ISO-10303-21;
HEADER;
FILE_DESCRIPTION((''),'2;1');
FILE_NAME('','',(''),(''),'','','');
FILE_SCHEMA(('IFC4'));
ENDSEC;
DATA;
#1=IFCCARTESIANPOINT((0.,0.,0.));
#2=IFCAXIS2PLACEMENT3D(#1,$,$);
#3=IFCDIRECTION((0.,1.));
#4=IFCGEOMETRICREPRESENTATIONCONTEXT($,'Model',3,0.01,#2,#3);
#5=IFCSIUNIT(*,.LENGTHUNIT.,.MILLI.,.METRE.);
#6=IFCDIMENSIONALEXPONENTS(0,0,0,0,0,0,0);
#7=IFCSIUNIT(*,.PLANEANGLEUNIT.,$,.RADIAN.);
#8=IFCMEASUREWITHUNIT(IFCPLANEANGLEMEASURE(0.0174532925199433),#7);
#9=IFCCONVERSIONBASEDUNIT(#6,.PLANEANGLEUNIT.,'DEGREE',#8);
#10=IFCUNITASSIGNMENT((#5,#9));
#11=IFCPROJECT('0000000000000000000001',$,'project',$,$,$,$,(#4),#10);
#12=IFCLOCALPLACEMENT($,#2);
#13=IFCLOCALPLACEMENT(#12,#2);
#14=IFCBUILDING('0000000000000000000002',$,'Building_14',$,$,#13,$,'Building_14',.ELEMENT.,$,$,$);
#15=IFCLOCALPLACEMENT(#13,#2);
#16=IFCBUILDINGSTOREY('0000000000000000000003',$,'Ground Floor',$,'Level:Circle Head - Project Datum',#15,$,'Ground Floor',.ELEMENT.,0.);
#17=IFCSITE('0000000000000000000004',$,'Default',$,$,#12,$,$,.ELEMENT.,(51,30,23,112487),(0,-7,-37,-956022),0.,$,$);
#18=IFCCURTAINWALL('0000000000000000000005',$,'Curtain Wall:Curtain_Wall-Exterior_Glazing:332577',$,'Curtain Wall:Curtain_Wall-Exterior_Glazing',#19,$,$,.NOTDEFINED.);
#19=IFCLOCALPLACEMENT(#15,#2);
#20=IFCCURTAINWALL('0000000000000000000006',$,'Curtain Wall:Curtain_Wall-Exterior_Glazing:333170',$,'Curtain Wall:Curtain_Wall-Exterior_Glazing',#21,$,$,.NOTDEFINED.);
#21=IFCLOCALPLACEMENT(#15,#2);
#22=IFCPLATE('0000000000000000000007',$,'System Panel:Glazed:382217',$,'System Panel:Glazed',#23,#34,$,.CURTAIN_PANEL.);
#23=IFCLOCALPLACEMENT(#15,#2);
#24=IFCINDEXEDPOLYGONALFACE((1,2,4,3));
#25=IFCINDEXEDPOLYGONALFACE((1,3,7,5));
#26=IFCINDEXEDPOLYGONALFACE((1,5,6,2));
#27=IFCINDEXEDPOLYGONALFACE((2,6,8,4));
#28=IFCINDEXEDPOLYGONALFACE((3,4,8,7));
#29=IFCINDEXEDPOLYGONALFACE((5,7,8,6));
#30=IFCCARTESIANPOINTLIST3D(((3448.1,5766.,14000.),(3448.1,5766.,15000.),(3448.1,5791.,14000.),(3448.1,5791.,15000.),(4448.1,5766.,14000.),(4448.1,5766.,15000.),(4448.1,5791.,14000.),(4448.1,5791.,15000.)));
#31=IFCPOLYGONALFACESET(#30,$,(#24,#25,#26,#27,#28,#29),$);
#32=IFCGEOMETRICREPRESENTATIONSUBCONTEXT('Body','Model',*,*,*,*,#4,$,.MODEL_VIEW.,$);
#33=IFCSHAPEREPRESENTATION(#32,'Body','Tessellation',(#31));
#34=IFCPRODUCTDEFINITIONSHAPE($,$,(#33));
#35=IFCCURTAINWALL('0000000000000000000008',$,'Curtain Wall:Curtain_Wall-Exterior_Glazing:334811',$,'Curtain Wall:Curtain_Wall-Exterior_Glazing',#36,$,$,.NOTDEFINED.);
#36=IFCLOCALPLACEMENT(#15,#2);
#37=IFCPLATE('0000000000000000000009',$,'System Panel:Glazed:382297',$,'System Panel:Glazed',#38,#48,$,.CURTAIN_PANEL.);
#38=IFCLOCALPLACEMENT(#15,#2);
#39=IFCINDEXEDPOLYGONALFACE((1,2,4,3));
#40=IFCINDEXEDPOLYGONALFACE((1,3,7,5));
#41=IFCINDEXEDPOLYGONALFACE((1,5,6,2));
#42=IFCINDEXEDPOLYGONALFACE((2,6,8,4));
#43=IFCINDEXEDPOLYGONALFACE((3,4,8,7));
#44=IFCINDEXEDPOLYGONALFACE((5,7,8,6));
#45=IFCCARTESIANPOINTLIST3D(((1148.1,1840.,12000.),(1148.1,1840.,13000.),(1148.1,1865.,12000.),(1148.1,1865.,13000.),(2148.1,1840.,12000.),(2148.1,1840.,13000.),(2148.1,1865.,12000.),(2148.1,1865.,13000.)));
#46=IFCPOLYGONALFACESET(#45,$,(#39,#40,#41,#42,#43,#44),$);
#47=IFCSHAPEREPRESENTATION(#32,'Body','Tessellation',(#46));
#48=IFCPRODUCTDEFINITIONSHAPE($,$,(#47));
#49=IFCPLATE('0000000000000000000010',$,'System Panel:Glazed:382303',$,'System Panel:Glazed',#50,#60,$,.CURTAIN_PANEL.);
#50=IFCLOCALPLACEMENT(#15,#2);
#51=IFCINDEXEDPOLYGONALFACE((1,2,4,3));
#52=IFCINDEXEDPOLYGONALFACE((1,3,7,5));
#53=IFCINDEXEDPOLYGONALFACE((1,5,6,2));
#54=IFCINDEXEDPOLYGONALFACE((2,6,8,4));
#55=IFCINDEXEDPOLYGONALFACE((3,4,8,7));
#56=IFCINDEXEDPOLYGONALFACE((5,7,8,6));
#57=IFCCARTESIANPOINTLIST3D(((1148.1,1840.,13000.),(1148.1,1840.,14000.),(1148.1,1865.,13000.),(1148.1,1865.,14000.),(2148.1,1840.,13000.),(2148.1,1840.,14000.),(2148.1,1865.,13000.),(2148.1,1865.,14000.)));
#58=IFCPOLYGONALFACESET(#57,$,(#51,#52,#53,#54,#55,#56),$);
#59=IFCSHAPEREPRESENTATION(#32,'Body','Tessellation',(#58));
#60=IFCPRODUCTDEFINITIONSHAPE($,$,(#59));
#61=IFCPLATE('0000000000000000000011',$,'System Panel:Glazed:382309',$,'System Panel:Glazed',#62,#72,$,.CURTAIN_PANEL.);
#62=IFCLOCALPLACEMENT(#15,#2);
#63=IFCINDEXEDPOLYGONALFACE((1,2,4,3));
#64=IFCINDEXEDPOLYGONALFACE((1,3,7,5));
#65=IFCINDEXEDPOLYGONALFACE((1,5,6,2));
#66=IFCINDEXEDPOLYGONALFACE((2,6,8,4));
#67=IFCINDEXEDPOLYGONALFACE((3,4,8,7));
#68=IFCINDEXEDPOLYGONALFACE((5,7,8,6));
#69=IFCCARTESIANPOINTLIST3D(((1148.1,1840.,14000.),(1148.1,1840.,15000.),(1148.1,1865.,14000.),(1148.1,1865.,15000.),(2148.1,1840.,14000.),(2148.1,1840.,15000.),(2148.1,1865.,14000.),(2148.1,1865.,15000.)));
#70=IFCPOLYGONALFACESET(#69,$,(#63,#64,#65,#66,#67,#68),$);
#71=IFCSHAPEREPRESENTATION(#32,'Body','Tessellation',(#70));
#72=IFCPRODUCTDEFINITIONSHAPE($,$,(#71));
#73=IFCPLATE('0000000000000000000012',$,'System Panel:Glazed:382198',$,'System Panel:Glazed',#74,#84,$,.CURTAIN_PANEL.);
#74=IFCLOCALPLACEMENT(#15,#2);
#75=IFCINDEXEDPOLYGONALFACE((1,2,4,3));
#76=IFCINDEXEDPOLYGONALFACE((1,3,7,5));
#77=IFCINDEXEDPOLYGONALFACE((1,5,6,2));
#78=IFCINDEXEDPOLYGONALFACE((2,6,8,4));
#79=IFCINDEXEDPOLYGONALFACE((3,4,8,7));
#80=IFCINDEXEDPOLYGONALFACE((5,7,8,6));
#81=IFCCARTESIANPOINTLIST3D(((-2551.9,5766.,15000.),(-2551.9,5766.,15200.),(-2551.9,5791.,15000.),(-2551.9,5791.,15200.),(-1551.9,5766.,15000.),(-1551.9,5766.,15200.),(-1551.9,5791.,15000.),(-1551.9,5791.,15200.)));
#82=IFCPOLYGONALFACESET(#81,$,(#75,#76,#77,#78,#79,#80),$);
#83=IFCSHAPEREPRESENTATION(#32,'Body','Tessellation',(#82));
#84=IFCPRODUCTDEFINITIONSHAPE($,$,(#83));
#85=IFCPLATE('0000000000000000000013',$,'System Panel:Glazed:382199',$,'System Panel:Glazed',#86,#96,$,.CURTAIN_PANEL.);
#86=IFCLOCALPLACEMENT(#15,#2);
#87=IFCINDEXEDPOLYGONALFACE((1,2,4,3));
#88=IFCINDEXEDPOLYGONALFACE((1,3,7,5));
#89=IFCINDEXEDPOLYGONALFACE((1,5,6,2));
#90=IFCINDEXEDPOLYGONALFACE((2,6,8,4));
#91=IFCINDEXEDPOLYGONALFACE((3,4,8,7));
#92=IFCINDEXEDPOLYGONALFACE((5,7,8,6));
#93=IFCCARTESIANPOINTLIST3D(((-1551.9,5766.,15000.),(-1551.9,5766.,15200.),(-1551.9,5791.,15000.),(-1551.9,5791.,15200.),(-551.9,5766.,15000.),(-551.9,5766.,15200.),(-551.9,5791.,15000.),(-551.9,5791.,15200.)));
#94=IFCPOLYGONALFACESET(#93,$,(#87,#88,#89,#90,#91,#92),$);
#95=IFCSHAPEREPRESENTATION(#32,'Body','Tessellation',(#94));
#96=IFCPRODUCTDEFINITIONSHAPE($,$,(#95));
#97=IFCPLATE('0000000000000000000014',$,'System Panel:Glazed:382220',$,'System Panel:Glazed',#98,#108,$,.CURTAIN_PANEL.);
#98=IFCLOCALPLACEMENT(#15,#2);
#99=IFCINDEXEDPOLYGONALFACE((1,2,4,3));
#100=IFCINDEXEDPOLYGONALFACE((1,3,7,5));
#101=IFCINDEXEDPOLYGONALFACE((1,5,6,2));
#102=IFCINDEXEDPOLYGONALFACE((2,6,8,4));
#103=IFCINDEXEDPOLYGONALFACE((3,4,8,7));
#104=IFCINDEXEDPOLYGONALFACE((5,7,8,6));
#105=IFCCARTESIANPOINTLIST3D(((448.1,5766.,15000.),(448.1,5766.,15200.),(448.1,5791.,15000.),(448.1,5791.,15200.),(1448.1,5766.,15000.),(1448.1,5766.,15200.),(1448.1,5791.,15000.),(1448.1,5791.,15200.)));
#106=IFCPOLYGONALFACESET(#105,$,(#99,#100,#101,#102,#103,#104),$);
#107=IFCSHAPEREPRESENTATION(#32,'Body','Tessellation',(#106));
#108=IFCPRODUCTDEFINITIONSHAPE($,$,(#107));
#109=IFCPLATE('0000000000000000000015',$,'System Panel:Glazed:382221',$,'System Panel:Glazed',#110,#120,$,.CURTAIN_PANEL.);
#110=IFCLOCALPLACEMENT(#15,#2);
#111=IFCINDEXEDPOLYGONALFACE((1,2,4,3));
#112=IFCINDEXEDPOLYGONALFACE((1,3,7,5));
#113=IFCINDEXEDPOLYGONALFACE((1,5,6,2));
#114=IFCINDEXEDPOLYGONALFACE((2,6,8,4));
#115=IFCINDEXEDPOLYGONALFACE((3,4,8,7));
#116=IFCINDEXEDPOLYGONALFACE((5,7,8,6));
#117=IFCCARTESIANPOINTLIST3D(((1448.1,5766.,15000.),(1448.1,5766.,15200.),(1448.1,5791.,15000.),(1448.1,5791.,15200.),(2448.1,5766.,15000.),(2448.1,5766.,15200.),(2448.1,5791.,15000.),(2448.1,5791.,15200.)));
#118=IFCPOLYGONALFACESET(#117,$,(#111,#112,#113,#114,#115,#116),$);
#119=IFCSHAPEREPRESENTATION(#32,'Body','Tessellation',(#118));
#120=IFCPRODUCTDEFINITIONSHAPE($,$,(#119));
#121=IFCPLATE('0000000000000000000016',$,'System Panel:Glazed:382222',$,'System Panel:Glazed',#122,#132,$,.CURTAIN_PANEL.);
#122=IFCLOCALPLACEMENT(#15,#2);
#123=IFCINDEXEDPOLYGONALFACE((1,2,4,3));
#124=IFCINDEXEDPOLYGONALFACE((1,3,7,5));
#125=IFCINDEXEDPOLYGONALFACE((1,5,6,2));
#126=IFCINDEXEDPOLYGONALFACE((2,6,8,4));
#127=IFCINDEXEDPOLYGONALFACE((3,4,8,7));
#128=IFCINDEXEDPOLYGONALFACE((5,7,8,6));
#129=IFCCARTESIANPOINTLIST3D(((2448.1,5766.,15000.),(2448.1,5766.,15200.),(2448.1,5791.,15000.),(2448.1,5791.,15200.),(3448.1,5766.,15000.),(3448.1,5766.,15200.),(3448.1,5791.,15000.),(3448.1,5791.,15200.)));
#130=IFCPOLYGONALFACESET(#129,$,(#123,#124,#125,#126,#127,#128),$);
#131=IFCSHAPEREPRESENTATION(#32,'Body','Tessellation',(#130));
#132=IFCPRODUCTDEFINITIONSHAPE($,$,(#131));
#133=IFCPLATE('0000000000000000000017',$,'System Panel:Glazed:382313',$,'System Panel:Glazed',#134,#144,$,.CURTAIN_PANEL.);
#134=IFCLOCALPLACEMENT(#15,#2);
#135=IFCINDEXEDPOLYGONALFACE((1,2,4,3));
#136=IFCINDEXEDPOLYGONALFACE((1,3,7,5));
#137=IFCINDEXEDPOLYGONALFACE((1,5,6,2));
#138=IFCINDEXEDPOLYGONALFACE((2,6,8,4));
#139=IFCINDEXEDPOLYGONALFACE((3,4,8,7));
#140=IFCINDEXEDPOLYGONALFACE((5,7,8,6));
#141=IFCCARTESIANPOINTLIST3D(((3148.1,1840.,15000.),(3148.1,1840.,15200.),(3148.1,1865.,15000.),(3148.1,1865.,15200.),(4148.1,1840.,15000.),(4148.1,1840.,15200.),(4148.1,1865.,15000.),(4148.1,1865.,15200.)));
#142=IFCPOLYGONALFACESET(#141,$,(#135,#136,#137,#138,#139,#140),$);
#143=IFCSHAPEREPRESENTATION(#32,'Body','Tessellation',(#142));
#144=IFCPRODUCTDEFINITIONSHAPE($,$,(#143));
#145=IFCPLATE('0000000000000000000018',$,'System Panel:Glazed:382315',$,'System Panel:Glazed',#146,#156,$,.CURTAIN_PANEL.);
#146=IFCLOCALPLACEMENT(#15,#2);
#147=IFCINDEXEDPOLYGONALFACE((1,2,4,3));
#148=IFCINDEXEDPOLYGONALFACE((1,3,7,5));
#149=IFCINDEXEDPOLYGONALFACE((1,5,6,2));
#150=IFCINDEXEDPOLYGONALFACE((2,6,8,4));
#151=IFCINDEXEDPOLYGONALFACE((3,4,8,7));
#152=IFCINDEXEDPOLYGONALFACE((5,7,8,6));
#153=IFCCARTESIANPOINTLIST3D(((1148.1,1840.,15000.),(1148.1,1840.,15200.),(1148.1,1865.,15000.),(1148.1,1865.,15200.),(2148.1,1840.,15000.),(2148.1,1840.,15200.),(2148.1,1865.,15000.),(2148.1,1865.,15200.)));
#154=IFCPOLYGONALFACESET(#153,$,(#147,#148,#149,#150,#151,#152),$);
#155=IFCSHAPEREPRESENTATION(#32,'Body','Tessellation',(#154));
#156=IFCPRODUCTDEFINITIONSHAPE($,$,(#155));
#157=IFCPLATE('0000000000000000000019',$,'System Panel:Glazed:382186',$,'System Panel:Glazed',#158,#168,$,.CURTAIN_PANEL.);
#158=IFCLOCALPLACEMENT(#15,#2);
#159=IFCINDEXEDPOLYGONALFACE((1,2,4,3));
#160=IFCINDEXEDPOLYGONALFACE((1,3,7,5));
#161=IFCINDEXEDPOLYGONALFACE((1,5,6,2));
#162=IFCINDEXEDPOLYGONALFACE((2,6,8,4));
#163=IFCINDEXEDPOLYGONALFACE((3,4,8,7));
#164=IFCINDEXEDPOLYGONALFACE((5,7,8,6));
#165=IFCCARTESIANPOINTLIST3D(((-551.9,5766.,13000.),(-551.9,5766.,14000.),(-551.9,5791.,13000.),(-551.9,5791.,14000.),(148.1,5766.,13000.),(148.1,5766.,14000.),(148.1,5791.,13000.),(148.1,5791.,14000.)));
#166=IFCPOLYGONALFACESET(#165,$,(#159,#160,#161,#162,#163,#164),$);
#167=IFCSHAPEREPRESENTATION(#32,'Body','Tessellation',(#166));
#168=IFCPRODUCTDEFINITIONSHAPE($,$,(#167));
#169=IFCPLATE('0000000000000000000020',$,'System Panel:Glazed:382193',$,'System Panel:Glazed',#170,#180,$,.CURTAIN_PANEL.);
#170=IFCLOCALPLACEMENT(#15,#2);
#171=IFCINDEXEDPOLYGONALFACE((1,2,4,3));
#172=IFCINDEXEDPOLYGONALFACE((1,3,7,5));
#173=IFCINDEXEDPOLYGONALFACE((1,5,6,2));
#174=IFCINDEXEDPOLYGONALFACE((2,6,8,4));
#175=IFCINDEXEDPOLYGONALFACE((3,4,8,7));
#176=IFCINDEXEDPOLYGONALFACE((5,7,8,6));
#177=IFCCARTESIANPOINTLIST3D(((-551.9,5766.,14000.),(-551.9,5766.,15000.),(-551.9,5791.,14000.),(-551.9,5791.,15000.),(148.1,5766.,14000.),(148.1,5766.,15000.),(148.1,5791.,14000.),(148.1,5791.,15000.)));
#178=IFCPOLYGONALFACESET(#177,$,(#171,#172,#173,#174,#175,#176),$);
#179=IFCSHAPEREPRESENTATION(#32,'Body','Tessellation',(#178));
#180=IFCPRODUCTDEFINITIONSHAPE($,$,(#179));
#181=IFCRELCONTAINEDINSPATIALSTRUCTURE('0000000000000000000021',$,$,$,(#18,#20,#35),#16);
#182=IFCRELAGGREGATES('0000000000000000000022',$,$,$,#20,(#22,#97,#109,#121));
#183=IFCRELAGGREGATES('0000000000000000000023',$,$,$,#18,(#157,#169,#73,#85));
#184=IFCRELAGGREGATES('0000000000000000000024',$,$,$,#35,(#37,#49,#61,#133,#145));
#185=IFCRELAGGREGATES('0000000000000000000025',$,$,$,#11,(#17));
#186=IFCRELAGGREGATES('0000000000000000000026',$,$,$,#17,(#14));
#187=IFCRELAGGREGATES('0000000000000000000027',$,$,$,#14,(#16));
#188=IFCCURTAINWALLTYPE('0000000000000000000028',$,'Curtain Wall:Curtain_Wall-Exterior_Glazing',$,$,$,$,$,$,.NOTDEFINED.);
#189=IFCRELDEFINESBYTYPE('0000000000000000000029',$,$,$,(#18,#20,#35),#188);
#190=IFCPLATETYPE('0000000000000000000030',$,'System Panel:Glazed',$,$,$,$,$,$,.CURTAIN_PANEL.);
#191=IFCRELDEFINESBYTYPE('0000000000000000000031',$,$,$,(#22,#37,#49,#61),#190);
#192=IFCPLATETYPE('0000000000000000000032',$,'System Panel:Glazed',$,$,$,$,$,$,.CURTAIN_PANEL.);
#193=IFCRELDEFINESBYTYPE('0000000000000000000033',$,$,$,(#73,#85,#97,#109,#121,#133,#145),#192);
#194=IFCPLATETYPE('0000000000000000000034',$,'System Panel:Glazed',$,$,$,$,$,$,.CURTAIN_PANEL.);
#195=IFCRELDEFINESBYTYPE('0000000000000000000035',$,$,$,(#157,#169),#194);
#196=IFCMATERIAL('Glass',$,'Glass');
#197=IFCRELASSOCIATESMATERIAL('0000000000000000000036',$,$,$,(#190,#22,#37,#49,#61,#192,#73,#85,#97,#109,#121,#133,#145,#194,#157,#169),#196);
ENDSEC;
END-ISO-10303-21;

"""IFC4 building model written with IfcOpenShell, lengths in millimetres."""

from ifc_helpers import new_model, entity, si_unit, converted_unit, direction, frame, origin, place, context, subcontext, project, spatial, indexed_curve, outline, extrude, source, transform, mapped, material, type_object, type_shapes, element, aggregate, save


model = new_model("IFC4")

# Units and contexts
model_context = context("Model", 3, precision=0.01, world=origin(), true_north=direction((0.0, 1.0)))
body_context = subcontext(model_context, "Body", "Model", "MODEL_VIEW")
ifc_project = project(units=[si_unit("LENGTHUNIT", "METRE", prefix="MILLI"), converted_unit("PLANEANGLEUNIT", "DEGREE", entity("IfcPlaneAngleMeasure", 0.0174532925199433), si_unit("PLANEANGLEUNIT", "RADIAN"), dimensions=[0, 0, 0, 0, 0, 0, 0])], contexts=[model_context])

# Site, building, storey
site_placement = place(None, origin())
site = spatial("IfcSite", under=ifc_project, at=site_placement, Name="Default", CompositionType="ELEMENT", RefLatitude=(51, 30, 23, 112487), RefLongitude=(0, -7, -37, -956022), RefElevation=0.0)
building_placement = place(site_placement, origin())
building = spatial("IfcBuilding", under=site, at=building_placement, Name="Building_14", LongName="Building_14", CompositionType="ELEMENT")
storey_placement = place(building_placement, origin())
storey = spatial("IfcBuildingStorey", under=building, at=storey_placement, Name="Ground Floor", ObjectType="Level:Circle Head - Project Datum", LongName="Ground Floor", CompositionType="ELEMENT", Elevation=0.0)

# Curtain walls, plates
curtain_wall_type = type_object("IfcCurtainWallType", Name="Curtain Wall:Curtain_Wall-Exterior_Glazing", PredefinedType="NOTDEFINED")
curtain_wall_1_placement = place(storey_placement, origin())
curtain_wall_1 = element("IfcCurtainWall", 1, at=curtain_wall_1_placement, inside=storey, type_object=curtain_wall_type, Name="Curtain Wall:Curtain_Wall-Exterior_Glazing:332577", ObjectType="Curtain Wall:Curtain_Wall-Exterior_Glazing", PredefinedType="NOTDEFINED")
ifc_material = material(Name="Glass", Category="Glass")
plate_type_1 = type_object("IfcPlateType", Name="System Panel:Glazed", PredefinedType="CURTAIN_PANEL", material=ifc_material)
shared_shape_1 = source(origin(), body_context, "Body", "SweptSolid", [
    extrude(outline(indexed_curve([(-12.5, -500.0), (12.5, -500.0), (12.5, 500.0), (-12.5, 500.0), (-12.5, -500.0)], self_intersect=False)), frame((0.0, -37.0, 0.0), z_axis=(0.0, 0.0, 1.0), x_axis=(0.0, 1.0, 0.0)), (0.0, 0.0, 1.0), 1000.0),
])
type_shapes(plate_type_1, [shared_shape_1])
curtain_wall_2_placement = place(storey_placement, origin())
curtain_wall_2 = element("IfcCurtainWall", 2, at=curtain_wall_2_placement, inside=storey, type_object=curtain_wall_type, Name="Curtain Wall:Curtain_Wall-Exterior_Glazing:333170", ObjectType="Curtain Wall:Curtain_Wall-Exterior_Glazing", PredefinedType="NOTDEFINED")
plate_1_placement = place(curtain_wall_2_placement, frame((3948.1, 5815.5, 14000.0)))
plate_1 = element("IfcPlate", 3, at=plate_1_placement, type_object=plate_type_1, material=ifc_material, Name="System Panel:Glazed:382217", ObjectType="System Panel:Glazed", PredefinedType="CURTAIN_PANEL", context=body_context, shape_type="MappedRepresentation", body=[
    mapped(shared_shape_1, transform((0.0, 0.0, 0.0), scale=1.0)),
])
curtain_wall_3_placement = place(storey_placement, origin())
curtain_wall_3 = element("IfcCurtainWall", 4, at=curtain_wall_3_placement, inside=storey, type_object=curtain_wall_type, Name="Curtain Wall:Curtain_Wall-Exterior_Glazing:334811", ObjectType="Curtain Wall:Curtain_Wall-Exterior_Glazing", PredefinedType="NOTDEFINED")
plate_2_placement = place(curtain_wall_3_placement, frame((1648.1, 1815.5, 12000.0), z_axis=(0.0, 0.0, 1.0), x_axis=(-1.0, 0.0, 0.0)))
plate_2 = element("IfcPlate", 5, at=plate_2_placement, type_object=plate_type_1, material=ifc_material, Name="System Panel:Glazed:382297", ObjectType="System Panel:Glazed", PredefinedType="CURTAIN_PANEL", context=body_context, shape_type="MappedRepresentation", body=[
    mapped(shared_shape_1, transform((0.0, 0.0, 0.0), scale=1.0)),
])
plate_3_placement = place(curtain_wall_3_placement, frame((1648.1, 1815.5, 13000.0), z_axis=(0.0, 0.0, 1.0), x_axis=(-1.0, 0.0, 0.0)))
plate_3 = element("IfcPlate", 6, at=plate_3_placement, type_object=plate_type_1, material=ifc_material, Name="System Panel:Glazed:382303", ObjectType="System Panel:Glazed", PredefinedType="CURTAIN_PANEL", context=body_context, shape_type="MappedRepresentation", body=[
    mapped(shared_shape_1, transform((0.0, 0.0, 0.0), scale=1.0)),
])
plate_4_placement = place(curtain_wall_3_placement, frame((1648.1, 1815.5, 14000.0), z_axis=(0.0, 0.0, 1.0), x_axis=(-1.0, 0.0, 0.0)))
plate_4 = element("IfcPlate", 7, at=plate_4_placement, type_object=plate_type_1, material=ifc_material, Name="System Panel:Glazed:382309", ObjectType="System Panel:Glazed", PredefinedType="CURTAIN_PANEL", context=body_context, shape_type="MappedRepresentation", body=[
    mapped(shared_shape_1, transform((0.0, 0.0, 0.0), scale=1.0)),
])

# Plates
plate_type_2 = type_object("IfcPlateType", Name="System Panel:Glazed", PredefinedType="CURTAIN_PANEL", material=ifc_material)
shared_shape_2 = source(origin(), body_context, "Body", "SweptSolid", [
    extrude(outline(indexed_curve([(-12.5, -500.0), (12.5, -500.0), (12.5, 500.0), (-12.5, 500.0), (-12.5, -500.0)], self_intersect=False)), frame((0.0, -37.0, 0.0), z_axis=(0.0, 0.0, 1.0), x_axis=(0.0, 1.0, 0.0)), (0.0, 0.0, 1.0), 200.0),
])
type_shapes(plate_type_2, [shared_shape_2])
plate_5_placement = place(curtain_wall_1_placement, frame((-2051.9, 5815.5, 15000.0)))
plate_5 = element("IfcPlate", 8, at=plate_5_placement, type_object=plate_type_2, material=ifc_material, Name="System Panel:Glazed:382198", ObjectType="System Panel:Glazed", PredefinedType="CURTAIN_PANEL", context=body_context, shape_type="MappedRepresentation", body=[
    mapped(shared_shape_2, transform((0.0, 0.0, 0.0), scale=1.0)),
])
plate_6_placement = place(curtain_wall_1_placement, frame((-1051.9, 5815.5, 15000.0)))
plate_6 = element("IfcPlate", 9, at=plate_6_placement, type_object=plate_type_2, material=ifc_material, Name="System Panel:Glazed:382199", ObjectType="System Panel:Glazed", PredefinedType="CURTAIN_PANEL", context=body_context, shape_type="MappedRepresentation", body=[
    mapped(shared_shape_2, transform((0.0, 0.0, 0.0), scale=1.0)),
])
plate_7_placement = place(curtain_wall_2_placement, frame((948.1, 5815.5, 15000.0)))
plate_7 = element("IfcPlate", 10, at=plate_7_placement, type_object=plate_type_2, material=ifc_material, Name="System Panel:Glazed:382220", ObjectType="System Panel:Glazed", PredefinedType="CURTAIN_PANEL", context=body_context, shape_type="MappedRepresentation", body=[
    mapped(shared_shape_2, transform((0.0, 0.0, 0.0), scale=1.0)),
])
plate_8_placement = place(curtain_wall_2_placement, frame((1948.1, 5815.5, 15000.0)))
plate_8 = element("IfcPlate", 11, at=plate_8_placement, type_object=plate_type_2, material=ifc_material, Name="System Panel:Glazed:382221", ObjectType="System Panel:Glazed", PredefinedType="CURTAIN_PANEL", context=body_context, shape_type="MappedRepresentation", body=[
    mapped(shared_shape_2, transform((0.0, 0.0, 0.0), scale=1.0)),
])
plate_9_placement = place(curtain_wall_2_placement, frame((2948.1, 5815.5, 15000.0)))
plate_9 = element("IfcPlate", 12, at=plate_9_placement, type_object=plate_type_2, material=ifc_material, Name="System Panel:Glazed:382222", ObjectType="System Panel:Glazed", PredefinedType="CURTAIN_PANEL", context=body_context, shape_type="MappedRepresentation", body=[
    mapped(shared_shape_2, transform((0.0, 0.0, 0.0), scale=1.0)),
])
aggregate(curtain_wall_2, [plate_1, plate_7, plate_8, plate_9])
plate_10_placement = place(curtain_wall_3_placement, frame((3648.1, 1815.5, 15000.0), z_axis=(0.0, 0.0, 1.0), x_axis=(-1.0, 0.0, 0.0)))
plate_10 = element("IfcPlate", 13, at=plate_10_placement, type_object=plate_type_2, material=ifc_material, Name="System Panel:Glazed:382313", ObjectType="System Panel:Glazed", PredefinedType="CURTAIN_PANEL", context=body_context, shape_type="MappedRepresentation", body=[
    mapped(shared_shape_2, transform((0.0, 0.0, 0.0), scale=1.0)),
])
plate_11_placement = place(curtain_wall_3_placement, frame((1648.1, 1815.5, 15000.0), z_axis=(0.0, 0.0, 1.0), x_axis=(-1.0, 0.0, 0.0)))
plate_11 = element("IfcPlate", 14, at=plate_11_placement, type_object=plate_type_2, material=ifc_material, Name="System Panel:Glazed:382315", ObjectType="System Panel:Glazed", PredefinedType="CURTAIN_PANEL", context=body_context, shape_type="MappedRepresentation", body=[
    mapped(shared_shape_2, transform((0.0, 0.0, 0.0), scale=1.0)),
])
plate_type_3 = type_object("IfcPlateType", Name="System Panel:Glazed", PredefinedType="CURTAIN_PANEL", material=ifc_material)
shared_shape_3 = source(origin(), body_context, "Body", "SweptSolid", [
    extrude(outline(indexed_curve([(-12.5, -350.0), (12.5, -350.0), (12.5, 350.0), (-12.5, 350.0), (-12.5, -350.0)], self_intersect=False)), frame((0.0, -37.0, 0.0), z_axis=(0.0, 0.0, 1.0), x_axis=(0.0, 1.0, 0.0)), (0.0, 0.0, 1.0), 1000.0),
])
type_shapes(plate_type_3, [shared_shape_3])
plate_12_placement = place(curtain_wall_1_placement, frame((-201.9, 5815.5, 13000.0)))
plate_12 = element("IfcPlate", 15, at=plate_12_placement, type_object=plate_type_3, material=ifc_material, Name="System Panel:Glazed:382186", ObjectType="System Panel:Glazed", PredefinedType="CURTAIN_PANEL", context=body_context, shape_type="MappedRepresentation", body=[
    mapped(shared_shape_3, transform((0.0, 0.0, 0.0), scale=1.0)),
])
plate_13_placement = place(curtain_wall_1_placement, frame((-201.9, 5815.5, 14000.0)))
plate_13 = element("IfcPlate", 16, at=plate_13_placement, type_object=plate_type_3, material=ifc_material, Name="System Panel:Glazed:382193", ObjectType="System Panel:Glazed", PredefinedType="CURTAIN_PANEL", context=body_context, shape_type="MappedRepresentation", body=[
    mapped(shared_shape_3, transform((0.0, 0.0, 0.0), scale=1.0)),
])
aggregate(curtain_wall_1, [plate_12, plate_13, plate_5, plate_6])
aggregate(curtain_wall_3, [plate_2, plate_3, plate_4, plate_10, plate_11])

save(model, "model.ifc")
